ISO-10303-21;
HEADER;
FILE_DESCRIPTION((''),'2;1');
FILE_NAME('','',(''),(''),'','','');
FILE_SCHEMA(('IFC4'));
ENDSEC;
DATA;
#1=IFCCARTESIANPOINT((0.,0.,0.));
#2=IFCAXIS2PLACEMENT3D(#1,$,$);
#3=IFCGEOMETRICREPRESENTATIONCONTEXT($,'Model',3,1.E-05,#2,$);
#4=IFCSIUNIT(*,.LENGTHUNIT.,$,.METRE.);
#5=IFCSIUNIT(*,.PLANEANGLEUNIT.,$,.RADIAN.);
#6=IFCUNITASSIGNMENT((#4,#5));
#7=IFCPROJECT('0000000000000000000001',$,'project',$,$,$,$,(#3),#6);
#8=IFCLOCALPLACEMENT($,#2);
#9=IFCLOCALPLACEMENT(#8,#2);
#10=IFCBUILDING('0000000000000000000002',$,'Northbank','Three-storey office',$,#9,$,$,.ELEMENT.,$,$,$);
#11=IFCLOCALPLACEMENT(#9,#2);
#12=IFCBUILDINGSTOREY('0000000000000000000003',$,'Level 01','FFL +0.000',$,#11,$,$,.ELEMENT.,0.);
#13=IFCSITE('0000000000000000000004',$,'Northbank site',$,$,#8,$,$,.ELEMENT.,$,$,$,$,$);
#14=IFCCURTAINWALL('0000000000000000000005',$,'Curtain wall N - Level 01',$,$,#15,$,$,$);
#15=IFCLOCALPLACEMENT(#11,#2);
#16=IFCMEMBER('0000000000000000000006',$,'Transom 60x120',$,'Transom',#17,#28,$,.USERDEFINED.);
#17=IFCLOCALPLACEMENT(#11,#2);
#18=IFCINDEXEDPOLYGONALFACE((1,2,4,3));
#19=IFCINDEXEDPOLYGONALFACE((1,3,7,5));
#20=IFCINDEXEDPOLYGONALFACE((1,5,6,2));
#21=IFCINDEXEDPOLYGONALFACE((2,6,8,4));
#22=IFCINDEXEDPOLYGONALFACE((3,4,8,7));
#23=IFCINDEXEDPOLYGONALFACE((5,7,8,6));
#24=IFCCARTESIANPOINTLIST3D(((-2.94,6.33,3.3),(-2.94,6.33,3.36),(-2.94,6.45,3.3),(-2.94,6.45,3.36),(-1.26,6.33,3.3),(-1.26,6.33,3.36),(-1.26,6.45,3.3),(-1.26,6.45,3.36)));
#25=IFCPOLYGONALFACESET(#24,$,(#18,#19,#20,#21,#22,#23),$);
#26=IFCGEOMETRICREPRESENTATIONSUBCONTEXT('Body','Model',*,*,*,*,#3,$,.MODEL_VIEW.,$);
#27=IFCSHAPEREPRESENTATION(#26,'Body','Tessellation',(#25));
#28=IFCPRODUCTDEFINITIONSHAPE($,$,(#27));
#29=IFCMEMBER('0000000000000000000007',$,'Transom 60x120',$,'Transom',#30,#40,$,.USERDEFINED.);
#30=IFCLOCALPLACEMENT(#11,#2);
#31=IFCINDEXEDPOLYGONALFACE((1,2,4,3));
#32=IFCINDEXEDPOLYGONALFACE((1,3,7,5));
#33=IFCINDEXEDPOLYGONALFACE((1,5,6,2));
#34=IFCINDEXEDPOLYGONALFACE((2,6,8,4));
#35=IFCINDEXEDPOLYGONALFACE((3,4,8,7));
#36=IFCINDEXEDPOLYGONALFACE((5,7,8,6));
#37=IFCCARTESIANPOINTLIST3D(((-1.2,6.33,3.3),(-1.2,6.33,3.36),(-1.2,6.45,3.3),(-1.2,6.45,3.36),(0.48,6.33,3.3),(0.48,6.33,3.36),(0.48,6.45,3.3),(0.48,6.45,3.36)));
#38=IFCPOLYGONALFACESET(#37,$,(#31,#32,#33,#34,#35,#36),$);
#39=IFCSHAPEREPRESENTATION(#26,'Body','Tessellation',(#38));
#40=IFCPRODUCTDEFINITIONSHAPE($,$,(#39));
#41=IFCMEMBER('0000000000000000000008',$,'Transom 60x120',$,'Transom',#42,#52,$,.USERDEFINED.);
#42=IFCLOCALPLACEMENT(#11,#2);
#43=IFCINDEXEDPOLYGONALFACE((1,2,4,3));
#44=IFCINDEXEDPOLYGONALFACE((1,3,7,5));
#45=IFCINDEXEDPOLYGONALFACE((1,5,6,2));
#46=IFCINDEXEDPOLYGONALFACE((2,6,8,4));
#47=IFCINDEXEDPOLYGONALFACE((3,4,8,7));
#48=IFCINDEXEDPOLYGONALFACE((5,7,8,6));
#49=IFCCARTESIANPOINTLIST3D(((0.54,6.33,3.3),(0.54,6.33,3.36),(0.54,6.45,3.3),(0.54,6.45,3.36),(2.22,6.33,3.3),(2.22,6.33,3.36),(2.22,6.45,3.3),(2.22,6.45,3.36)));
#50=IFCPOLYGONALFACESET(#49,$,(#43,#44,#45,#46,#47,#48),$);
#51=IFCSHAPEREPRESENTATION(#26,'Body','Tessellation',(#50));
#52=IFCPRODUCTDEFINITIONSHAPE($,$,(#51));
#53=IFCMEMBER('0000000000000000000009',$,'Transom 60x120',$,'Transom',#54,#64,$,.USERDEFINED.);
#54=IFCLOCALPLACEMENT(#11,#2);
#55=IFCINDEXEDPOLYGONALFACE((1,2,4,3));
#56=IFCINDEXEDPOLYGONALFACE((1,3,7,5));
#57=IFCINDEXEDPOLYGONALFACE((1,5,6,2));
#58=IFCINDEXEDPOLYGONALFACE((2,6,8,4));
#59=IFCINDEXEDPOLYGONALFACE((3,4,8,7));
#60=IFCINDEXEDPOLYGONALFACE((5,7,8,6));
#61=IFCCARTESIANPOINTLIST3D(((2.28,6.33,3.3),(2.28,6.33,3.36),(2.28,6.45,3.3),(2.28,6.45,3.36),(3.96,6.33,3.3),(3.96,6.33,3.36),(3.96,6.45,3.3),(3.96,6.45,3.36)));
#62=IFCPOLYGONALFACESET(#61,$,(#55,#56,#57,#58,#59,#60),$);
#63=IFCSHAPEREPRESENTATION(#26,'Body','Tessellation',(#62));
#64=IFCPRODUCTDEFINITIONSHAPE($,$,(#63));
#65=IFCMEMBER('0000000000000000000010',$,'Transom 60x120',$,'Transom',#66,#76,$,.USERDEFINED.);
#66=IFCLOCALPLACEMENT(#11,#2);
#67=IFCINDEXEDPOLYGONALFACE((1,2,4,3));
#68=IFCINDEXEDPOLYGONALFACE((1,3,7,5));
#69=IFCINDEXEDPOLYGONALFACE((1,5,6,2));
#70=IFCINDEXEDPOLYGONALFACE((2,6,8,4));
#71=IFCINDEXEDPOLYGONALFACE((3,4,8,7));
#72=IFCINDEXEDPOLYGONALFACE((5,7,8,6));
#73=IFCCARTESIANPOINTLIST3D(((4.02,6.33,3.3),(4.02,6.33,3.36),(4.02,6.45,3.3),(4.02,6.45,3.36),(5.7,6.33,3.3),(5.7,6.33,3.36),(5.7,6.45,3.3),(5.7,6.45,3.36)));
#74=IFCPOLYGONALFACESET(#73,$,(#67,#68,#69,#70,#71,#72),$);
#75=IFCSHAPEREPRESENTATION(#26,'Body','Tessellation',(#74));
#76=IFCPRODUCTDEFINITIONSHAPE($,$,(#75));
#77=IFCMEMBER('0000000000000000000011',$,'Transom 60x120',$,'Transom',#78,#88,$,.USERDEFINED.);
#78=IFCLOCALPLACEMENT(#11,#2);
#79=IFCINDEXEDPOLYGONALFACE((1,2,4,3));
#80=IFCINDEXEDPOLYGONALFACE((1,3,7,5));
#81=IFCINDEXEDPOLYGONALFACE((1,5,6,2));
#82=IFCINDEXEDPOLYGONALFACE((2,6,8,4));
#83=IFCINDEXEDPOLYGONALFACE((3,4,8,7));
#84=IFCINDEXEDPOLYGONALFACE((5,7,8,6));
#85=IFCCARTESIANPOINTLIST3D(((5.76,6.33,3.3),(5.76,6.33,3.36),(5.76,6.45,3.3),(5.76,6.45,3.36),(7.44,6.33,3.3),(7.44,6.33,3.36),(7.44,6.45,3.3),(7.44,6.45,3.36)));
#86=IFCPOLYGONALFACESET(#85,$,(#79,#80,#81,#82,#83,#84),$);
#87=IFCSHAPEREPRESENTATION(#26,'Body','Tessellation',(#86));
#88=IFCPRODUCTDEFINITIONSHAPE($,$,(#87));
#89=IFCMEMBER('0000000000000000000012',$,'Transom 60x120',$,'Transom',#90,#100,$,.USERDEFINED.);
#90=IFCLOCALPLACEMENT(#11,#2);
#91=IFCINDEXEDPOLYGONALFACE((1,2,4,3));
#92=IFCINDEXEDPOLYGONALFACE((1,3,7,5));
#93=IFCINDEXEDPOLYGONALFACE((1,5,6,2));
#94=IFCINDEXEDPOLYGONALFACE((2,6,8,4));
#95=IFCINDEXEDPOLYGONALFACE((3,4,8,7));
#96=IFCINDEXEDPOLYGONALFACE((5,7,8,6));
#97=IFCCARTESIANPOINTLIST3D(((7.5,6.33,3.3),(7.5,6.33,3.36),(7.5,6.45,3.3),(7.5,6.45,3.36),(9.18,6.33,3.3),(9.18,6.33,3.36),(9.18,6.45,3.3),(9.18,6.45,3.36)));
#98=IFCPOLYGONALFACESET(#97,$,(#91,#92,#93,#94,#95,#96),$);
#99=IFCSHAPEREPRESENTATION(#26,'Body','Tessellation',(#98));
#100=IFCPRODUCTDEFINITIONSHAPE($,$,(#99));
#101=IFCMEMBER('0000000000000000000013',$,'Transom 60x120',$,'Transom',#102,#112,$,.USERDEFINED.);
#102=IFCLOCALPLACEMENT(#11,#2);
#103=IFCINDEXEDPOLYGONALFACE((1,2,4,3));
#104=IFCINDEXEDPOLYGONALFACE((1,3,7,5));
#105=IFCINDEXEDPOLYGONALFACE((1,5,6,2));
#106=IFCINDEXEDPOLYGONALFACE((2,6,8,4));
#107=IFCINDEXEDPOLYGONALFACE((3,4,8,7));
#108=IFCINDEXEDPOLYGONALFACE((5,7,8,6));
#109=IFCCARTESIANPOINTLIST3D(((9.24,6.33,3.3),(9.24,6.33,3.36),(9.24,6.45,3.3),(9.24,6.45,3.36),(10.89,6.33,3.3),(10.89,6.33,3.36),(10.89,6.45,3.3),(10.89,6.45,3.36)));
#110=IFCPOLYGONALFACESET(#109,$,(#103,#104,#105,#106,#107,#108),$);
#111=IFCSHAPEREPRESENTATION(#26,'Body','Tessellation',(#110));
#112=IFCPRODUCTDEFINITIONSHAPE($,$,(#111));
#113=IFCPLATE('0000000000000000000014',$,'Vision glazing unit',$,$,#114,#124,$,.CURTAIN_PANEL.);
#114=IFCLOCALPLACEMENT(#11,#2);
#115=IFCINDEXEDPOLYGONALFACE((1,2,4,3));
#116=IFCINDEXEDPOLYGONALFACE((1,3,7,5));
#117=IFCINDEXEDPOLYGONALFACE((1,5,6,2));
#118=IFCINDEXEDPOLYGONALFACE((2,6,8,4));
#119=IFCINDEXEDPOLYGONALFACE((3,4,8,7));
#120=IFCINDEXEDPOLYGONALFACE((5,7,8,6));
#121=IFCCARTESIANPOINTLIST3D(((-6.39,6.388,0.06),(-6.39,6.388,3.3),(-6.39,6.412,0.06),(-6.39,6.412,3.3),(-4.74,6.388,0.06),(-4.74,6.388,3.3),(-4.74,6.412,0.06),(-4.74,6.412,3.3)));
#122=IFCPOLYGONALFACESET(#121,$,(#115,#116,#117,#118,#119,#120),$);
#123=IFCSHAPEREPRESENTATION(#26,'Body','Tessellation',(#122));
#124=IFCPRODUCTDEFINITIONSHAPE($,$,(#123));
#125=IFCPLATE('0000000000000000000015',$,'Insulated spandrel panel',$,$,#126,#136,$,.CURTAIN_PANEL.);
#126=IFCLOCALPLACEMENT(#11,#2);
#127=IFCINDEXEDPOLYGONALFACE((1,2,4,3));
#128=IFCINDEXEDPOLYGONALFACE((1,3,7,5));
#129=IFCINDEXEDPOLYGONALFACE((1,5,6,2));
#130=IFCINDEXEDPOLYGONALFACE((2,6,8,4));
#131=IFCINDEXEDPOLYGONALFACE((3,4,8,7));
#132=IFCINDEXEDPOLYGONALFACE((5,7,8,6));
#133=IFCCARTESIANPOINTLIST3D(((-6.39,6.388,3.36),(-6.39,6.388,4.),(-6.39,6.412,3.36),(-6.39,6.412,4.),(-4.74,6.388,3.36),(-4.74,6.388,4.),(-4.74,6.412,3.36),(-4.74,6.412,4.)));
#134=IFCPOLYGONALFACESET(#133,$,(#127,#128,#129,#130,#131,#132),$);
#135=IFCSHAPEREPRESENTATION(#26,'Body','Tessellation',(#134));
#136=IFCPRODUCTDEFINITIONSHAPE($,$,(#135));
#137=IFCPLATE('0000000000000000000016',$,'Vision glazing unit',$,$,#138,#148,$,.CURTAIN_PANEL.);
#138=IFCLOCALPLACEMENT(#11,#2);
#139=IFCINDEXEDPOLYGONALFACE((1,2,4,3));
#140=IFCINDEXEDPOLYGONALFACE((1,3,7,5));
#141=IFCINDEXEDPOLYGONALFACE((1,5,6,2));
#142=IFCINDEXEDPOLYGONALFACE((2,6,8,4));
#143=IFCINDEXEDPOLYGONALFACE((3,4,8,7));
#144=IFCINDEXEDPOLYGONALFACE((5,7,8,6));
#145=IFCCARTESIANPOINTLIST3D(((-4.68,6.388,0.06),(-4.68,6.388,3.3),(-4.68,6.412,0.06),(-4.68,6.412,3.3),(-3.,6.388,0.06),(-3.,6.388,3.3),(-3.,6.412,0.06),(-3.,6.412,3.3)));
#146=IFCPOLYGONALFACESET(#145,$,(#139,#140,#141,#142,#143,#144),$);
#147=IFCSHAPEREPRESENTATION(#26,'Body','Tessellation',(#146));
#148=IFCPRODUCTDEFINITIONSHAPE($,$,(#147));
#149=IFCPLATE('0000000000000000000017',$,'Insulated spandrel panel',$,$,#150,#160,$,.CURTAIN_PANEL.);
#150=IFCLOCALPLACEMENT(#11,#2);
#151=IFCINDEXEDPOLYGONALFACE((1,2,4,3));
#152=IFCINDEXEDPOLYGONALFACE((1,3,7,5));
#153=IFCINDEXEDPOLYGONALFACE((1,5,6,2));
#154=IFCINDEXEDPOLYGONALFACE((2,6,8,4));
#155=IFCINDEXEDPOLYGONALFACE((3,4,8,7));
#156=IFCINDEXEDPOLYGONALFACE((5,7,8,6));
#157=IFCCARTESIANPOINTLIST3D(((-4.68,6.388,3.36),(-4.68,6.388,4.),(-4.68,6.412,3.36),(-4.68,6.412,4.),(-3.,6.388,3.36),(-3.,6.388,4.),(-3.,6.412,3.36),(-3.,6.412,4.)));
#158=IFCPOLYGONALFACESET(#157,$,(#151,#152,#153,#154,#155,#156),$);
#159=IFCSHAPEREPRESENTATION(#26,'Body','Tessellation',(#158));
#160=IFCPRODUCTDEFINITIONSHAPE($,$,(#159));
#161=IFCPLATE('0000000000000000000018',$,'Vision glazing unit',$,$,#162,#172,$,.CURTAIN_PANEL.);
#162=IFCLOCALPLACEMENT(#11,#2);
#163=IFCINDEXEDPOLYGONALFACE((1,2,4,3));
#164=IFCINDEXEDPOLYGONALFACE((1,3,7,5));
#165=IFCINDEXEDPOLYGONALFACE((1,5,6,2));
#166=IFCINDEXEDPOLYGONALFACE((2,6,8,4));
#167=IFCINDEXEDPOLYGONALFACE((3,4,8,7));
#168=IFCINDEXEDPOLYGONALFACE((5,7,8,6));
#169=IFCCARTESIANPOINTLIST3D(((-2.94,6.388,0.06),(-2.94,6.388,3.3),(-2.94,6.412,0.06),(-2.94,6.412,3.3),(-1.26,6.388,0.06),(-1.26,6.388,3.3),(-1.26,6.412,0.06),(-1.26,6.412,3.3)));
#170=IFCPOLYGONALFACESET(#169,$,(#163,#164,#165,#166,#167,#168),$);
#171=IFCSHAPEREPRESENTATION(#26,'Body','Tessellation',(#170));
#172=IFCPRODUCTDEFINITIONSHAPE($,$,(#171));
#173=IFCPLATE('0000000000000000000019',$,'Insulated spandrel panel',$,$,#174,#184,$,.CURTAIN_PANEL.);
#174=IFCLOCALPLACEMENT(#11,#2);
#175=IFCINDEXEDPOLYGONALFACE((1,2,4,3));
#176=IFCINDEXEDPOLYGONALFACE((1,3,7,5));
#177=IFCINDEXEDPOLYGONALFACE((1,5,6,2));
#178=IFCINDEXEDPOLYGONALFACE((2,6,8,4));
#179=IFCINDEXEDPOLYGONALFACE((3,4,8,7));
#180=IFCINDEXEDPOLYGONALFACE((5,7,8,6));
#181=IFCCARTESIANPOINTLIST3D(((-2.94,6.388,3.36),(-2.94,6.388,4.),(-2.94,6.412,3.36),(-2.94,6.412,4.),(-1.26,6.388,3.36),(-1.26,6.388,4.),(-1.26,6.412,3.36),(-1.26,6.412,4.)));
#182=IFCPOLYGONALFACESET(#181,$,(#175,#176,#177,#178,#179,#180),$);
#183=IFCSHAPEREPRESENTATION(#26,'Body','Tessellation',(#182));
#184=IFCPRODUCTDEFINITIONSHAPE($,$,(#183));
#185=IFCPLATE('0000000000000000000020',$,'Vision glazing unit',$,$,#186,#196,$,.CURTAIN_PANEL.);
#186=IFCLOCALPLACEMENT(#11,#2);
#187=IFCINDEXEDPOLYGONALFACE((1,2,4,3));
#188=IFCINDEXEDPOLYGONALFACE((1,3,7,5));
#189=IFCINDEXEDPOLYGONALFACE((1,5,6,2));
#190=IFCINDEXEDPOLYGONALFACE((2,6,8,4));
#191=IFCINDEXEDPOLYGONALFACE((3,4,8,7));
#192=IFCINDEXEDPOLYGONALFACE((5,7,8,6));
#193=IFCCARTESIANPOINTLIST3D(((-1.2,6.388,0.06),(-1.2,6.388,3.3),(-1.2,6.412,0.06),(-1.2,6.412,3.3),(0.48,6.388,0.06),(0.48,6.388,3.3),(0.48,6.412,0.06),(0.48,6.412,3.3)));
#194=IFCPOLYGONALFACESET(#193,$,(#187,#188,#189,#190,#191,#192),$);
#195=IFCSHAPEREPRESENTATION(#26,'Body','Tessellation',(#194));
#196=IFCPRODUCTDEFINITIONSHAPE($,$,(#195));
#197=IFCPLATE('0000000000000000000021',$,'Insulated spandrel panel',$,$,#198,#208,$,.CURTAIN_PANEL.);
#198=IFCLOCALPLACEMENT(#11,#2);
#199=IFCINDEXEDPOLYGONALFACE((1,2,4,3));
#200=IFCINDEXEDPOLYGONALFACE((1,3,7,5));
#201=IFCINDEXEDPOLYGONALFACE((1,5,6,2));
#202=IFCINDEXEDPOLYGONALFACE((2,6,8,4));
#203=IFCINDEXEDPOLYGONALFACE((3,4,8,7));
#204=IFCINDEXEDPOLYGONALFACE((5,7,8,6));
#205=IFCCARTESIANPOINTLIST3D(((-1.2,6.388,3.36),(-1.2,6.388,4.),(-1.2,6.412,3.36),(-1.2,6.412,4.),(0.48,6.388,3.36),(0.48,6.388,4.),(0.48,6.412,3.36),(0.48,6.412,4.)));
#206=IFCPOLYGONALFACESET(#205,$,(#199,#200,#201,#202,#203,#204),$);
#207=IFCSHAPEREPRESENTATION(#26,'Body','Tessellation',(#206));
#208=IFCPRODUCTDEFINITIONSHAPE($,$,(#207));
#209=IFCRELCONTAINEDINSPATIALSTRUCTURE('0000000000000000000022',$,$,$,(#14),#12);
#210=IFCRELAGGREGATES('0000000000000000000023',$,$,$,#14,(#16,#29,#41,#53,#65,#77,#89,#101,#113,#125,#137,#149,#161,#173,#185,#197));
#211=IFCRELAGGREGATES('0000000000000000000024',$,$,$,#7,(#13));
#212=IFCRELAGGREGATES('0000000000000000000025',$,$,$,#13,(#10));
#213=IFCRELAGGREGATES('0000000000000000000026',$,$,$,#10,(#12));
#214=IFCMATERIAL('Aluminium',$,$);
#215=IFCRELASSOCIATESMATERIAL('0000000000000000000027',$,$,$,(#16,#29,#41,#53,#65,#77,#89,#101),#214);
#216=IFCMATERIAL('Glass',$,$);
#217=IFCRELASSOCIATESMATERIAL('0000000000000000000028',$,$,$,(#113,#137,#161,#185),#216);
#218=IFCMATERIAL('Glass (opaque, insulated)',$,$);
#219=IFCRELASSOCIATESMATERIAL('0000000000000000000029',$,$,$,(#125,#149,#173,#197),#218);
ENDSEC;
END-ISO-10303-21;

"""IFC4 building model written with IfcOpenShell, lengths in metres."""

from ifc_helpers import new_model, si_unit, frame, origin, place, context, subcontext, project, spatial, rectangle, extrude, material, element, aggregate, save


model = new_model("IFC4")

# Units and contexts
model_context = context("Model", 3, precision=1e-05, world=origin())
body_context = subcontext(model_context, "Body", "Model", "MODEL_VIEW")
ifc_project = project(units=[si_unit("LENGTHUNIT", "METRE"), si_unit("PLANEANGLEUNIT", "RADIAN")], contexts=[model_context])

# Site, building, storey
site_placement = place(None, origin())
site = spatial("IfcSite", under=ifc_project, at=site_placement, Name="Northbank site", CompositionType="ELEMENT")
building_placement = place(site_placement, origin())
building = spatial("IfcBuilding", under=site, at=building_placement, Name="Northbank", Description="Three-storey office", CompositionType="ELEMENT")
storey_placement = place(building_placement, origin())
storey = spatial("IfcBuildingStorey", under=building, at=storey_placement, Name="Level 01", Description="FFL +0.000", CompositionType="ELEMENT", Elevation=0.0)

# Curtain wall, members, plates
curtain_wall_placement = place(storey_placement, origin())
curtain_wall = element("IfcCurtainWall", 1, at=curtain_wall_placement, inside=storey, Name="Curtain wall N - Level 01")
ifc_material_1 = material(Name="Aluminium")
member_1_placement = place(storey_placement, origin())
member_1 = element("IfcMember", 2, at=member_1_placement, material=ifc_material_1, Name="Transom 60x120", ObjectType="Transom", PredefinedType="USERDEFINED", context=body_context, shape_type="SweptSolid", body=[
    extrude(rectangle(XDim=1.68, YDim=0.12), frame((-2.1, 6.39, 3.3)), (0.0, 0.0, 1.0), 0.06),
])
member_2_placement = place(storey_placement, origin())
member_2 = element("IfcMember", 3, at=member_2_placement, material=ifc_material_1, Name="Transom 60x120", ObjectType="Transom", PredefinedType="USERDEFINED", context=body_context, shape_type="SweptSolid", body=[
    extrude(rectangle(XDim=1.68, YDim=0.12), frame((-0.36, 6.39, 3.3)), (0.0, 0.0, 1.0), 0.06),
])
member_3_placement = place(storey_placement, origin())
member_3 = element("IfcMember", 4, at=member_3_placement, material=ifc_material_1, Name="Transom 60x120", ObjectType="Transom", PredefinedType="USERDEFINED", context=body_context, shape_type="SweptSolid", body=[
    extrude(rectangle(XDim=1.68, YDim=0.12), frame((1.38, 6.39, 3.3)), (0.0, 0.0, 1.0), 0.06),
])
member_4_placement = place(storey_placement, origin())
member_4 = element("IfcMember", 5, at=member_4_placement, material=ifc_material_1, Name="Transom 60x120", ObjectType="Transom", PredefinedType="USERDEFINED", context=body_context, shape_type="SweptSolid", body=[
    extrude(rectangle(XDim=1.68, YDim=0.12), frame((3.12, 6.39, 3.3)), (0.0, 0.0, 1.0), 0.06),
])
member_5_placement = place(storey_placement, origin())
member_5 = element("IfcMember", 6, at=member_5_placement, material=ifc_material_1, Name="Transom 60x120", ObjectType="Transom", PredefinedType="USERDEFINED", context=body_context, shape_type="SweptSolid", body=[
    extrude(rectangle(XDim=1.68, YDim=0.12), frame((4.86, 6.39, 3.3)), (0.0, 0.0, 1.0), 0.06),
])
member_6_placement = place(storey_placement, origin())
member_6 = element("IfcMember", 7, at=member_6_placement, material=ifc_material_1, Name="Transom 60x120", ObjectType="Transom", PredefinedType="USERDEFINED", context=body_context, shape_type="SweptSolid", body=[
    extrude(rectangle(XDim=1.68, YDim=0.12), frame((6.6, 6.39, 3.3)), (0.0, 0.0, 1.0), 0.06),
])
member_7_placement = place(storey_placement, origin())
member_7 = element("IfcMember", 8, at=member_7_placement, material=ifc_material_1, Name="Transom 60x120", ObjectType="Transom", PredefinedType="USERDEFINED", context=body_context, shape_type="SweptSolid", body=[
    extrude(rectangle(XDim=1.68, YDim=0.12), frame((8.34, 6.39, 3.3)), (0.0, 0.0, 1.0), 0.06),
])
member_8_placement = place(storey_placement, origin())
member_8 = element("IfcMember", 9, at=member_8_placement, material=ifc_material_1, Name="Transom 60x120", ObjectType="Transom", PredefinedType="USERDEFINED", context=body_context, shape_type="SweptSolid", body=[
    extrude(rectangle(XDim=1.65, YDim=0.12), frame((10.065, 6.39, 3.3)), (0.0, 0.0, 1.0), 0.06),
])
ifc_material_2 = material(Name="Glass")
plate_1_placement = place(storey_placement, origin())
plate_1 = element("IfcPlate", 10, at=plate_1_placement, material=ifc_material_2, Name="Vision glazing unit", PredefinedType="CURTAIN_PANEL", context=body_context, shape_type="SweptSolid", body=[
    extrude(rectangle(XDim=1.65, YDim=0.024), frame((-5.565, 6.4, 0.06)), (0.0, 0.0, 1.0), 3.24),
])
ifc_material_3 = material(Name="Glass (opaque, insulated)")
plate_2_placement = place(storey_placement, origin())
plate_2 = element("IfcPlate", 11, at=plate_2_placement, material=ifc_material_3, Name="Insulated spandrel panel", PredefinedType="CURTAIN_PANEL", context=body_context, shape_type="SweptSolid", body=[
    extrude(rectangle(XDim=1.65, YDim=0.024), frame((-5.565, 6.4, 3.36)), (0.0, 0.0, 1.0), 0.64),
])
plate_3_placement = place(storey_placement, origin())
plate_3 = element("IfcPlate", 12, at=plate_3_placement, material=ifc_material_2, Name="Vision glazing unit", PredefinedType="CURTAIN_PANEL", context=body_context, shape_type="SweptSolid", body=[
    extrude(rectangle(XDim=1.68, YDim=0.024), frame((-3.84, 6.4, 0.06)), (0.0, 0.0, 1.0), 3.24),
])
plate_4_placement = place(storey_placement, origin())
plate_4 = element("IfcPlate", 13, at=plate_4_placement, material=ifc_material_3, Name="Insulated spandrel panel", PredefinedType="CURTAIN_PANEL", context=body_context, shape_type="SweptSolid", body=[
    extrude(rectangle(XDim=1.68, YDim=0.024), frame((-3.84, 6.4, 3.36)), (0.0, 0.0, 1.0), 0.64),
])
plate_5_placement = place(storey_placement, origin())
plate_5 = element("IfcPlate", 14, at=plate_5_placement, material=ifc_material_2, Name="Vision glazing unit", PredefinedType="CURTAIN_PANEL", context=body_context, shape_type="SweptSolid", body=[
    extrude(rectangle(XDim=1.68, YDim=0.024), frame((-2.1, 6.4, 0.06)), (0.0, 0.0, 1.0), 3.24),
])
plate_6_placement = place(storey_placement, origin())
plate_6 = element("IfcPlate", 15, at=plate_6_placement, material=ifc_material_3, Name="Insulated spandrel panel", PredefinedType="CURTAIN_PANEL", context=body_context, shape_type="SweptSolid", body=[
    extrude(rectangle(XDim=1.68, YDim=0.024), frame((-2.1, 6.4, 3.36)), (0.0, 0.0, 1.0), 0.64),
])
plate_7_placement = place(storey_placement, origin())
plate_7 = element("IfcPlate", 16, at=plate_7_placement, material=ifc_material_2, Name="Vision glazing unit", PredefinedType="CURTAIN_PANEL", context=body_context, shape_type="SweptSolid", body=[
    extrude(rectangle(XDim=1.68, YDim=0.024), frame((-0.36, 6.4, 0.06)), (0.0, 0.0, 1.0), 3.24),
])
plate_8_placement = place(storey_placement, origin())
plate_8 = element("IfcPlate", 17, at=plate_8_placement, material=ifc_material_3, Name="Insulated spandrel panel", PredefinedType="CURTAIN_PANEL", context=body_context, shape_type="SweptSolid", body=[
    extrude(rectangle(XDim=1.68, YDim=0.024), frame((-0.36, 6.4, 3.36)), (0.0, 0.0, 1.0), 0.64),
])
aggregate(curtain_wall, [member_1, member_2, member_3, member_4, member_5, member_6, member_7, member_8, plate_1, plate_2, plate_3, plate_4, plate_5, plate_6, plate_7, plate_8])

save(model, "model.ifc")
